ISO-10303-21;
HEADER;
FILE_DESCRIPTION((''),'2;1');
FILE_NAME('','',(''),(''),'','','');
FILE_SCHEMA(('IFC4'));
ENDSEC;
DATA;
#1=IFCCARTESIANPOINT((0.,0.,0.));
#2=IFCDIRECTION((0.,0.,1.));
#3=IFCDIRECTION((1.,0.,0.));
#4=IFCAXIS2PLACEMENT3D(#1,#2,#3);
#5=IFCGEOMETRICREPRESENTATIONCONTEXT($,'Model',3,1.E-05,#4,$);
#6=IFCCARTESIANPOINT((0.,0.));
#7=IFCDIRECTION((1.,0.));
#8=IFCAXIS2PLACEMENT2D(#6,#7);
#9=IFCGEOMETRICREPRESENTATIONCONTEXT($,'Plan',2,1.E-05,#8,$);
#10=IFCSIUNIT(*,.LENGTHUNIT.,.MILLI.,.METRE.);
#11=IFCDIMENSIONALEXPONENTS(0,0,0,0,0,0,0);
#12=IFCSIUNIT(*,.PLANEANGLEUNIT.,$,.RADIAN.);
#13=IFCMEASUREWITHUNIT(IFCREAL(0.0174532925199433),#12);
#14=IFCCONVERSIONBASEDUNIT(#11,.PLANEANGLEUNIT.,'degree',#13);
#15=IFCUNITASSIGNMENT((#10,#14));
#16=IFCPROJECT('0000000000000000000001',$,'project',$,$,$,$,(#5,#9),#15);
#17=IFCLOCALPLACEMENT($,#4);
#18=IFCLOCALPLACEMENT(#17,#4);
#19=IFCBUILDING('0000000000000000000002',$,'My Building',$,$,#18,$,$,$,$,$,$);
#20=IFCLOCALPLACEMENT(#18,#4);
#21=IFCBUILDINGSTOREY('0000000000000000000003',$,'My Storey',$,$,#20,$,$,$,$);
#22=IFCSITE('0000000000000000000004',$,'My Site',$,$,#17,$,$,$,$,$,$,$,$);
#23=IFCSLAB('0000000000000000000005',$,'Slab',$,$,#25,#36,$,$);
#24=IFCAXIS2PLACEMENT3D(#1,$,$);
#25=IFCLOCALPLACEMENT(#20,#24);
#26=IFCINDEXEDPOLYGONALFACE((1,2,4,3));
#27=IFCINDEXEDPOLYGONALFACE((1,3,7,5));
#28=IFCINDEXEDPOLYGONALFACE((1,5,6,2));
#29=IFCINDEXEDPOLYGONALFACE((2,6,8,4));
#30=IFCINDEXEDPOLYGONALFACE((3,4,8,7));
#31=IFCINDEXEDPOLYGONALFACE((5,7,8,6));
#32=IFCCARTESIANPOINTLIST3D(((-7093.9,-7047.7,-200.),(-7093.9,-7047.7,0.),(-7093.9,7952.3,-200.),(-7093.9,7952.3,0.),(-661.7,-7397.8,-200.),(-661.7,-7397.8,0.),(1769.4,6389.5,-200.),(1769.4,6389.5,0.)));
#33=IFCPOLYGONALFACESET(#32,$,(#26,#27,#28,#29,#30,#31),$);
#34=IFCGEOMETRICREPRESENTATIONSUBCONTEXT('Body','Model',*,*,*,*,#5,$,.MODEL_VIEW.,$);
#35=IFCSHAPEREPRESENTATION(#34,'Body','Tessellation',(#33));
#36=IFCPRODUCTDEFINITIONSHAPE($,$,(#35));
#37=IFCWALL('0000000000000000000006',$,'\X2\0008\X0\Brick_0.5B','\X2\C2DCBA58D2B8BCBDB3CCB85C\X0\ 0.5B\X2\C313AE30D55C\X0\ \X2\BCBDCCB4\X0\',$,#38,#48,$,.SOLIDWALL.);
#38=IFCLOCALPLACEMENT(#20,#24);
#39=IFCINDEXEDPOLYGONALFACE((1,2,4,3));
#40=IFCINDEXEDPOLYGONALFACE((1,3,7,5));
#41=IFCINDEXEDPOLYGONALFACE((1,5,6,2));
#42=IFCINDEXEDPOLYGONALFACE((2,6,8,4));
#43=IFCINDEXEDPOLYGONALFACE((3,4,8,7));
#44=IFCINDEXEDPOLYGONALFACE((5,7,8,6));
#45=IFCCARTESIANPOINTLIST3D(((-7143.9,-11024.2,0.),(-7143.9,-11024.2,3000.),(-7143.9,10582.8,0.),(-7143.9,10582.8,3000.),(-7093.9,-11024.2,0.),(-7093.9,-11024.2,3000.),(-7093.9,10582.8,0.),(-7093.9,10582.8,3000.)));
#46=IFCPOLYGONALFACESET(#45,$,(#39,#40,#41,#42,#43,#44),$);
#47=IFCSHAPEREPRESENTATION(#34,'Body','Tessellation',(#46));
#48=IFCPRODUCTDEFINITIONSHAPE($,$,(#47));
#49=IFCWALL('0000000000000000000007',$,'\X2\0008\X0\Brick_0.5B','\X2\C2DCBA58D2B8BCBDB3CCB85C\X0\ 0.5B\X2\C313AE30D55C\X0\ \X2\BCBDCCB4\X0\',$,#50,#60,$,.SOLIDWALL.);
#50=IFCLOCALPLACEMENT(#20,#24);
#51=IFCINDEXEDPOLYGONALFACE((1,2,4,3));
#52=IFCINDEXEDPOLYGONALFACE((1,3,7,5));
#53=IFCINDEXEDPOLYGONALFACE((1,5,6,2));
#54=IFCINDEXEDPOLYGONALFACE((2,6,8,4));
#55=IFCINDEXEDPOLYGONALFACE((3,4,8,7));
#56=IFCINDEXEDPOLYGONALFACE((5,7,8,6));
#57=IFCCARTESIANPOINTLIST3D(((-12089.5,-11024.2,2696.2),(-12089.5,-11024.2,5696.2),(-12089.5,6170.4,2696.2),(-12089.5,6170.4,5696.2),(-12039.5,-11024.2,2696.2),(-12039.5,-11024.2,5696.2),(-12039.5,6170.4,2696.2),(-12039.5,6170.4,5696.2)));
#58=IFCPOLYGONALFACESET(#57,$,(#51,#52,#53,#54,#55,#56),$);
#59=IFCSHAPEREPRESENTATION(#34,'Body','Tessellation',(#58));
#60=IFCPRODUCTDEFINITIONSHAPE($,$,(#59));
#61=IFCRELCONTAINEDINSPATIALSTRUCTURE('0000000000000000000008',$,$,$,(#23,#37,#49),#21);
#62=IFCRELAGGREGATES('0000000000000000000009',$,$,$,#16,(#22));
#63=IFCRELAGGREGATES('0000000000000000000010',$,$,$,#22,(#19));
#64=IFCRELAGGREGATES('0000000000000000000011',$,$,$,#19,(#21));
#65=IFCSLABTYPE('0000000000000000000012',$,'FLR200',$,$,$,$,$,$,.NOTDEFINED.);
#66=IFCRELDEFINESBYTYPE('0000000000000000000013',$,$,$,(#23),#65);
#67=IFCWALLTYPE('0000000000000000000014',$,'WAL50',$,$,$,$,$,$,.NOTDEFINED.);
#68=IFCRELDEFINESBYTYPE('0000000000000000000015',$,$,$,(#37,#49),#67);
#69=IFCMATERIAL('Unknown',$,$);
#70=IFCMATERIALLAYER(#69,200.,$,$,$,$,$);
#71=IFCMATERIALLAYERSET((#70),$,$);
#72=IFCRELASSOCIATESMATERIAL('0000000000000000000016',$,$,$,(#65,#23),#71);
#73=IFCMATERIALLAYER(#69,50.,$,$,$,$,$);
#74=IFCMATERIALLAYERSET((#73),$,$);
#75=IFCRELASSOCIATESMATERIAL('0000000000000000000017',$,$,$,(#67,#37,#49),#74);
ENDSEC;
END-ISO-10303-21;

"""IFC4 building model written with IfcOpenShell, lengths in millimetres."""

from ifc_helpers import new_model, entity, si_unit, converted_unit, frame, origin_with_axes, origin_2d_with_axis, place, context, subcontext, project, spatial, line, indexed_curve, outline, extrude, material, layer, layer_set, layer_usage, type_object, element, save


model = new_model("IFC4")

# Units and contexts
model_context = context("Model", 3, precision=1e-05, world=origin_with_axes())
plan_context = context("Plan", 2, precision=1e-05, world=origin_2d_with_axis())
body_context = subcontext(model_context, "Body", "Model", "MODEL_VIEW")
ifc_project = project(units=[si_unit("LENGTHUNIT", "METRE", prefix="MILLI"), converted_unit("PLANEANGLEUNIT", "degree", entity("IfcReal", 0.0174532925199433), si_unit("PLANEANGLEUNIT", "RADIAN"), dimensions=[0, 0, 0, 0, 0, 0, 0])], contexts=[model_context, plan_context])

# Site, building, storey
site_placement = place(None, origin_with_axes())
site = spatial("IfcSite", under=ifc_project, at=site_placement, Name="My Site")
building_placement = place(site_placement, origin_with_axes())
building = spatial("IfcBuilding", under=site, at=building_placement, Name="My Building")
storey_placement = place(building_placement, origin_with_axes())
storey = spatial("IfcBuildingStorey", under=building, at=storey_placement, Name="My Storey")

# Slab
ifc_material = material(Name="Unknown")
ifc_layer_1 = layer(ifc_material, 200.0)
ifc_layer_set_1 = layer_set([ifc_layer_1])
ifc_layer_usage_1 = layer_usage(ifc_layer_set_1, "AXIS3", "POSITIVE", -200.0)
slab_type = type_object("IfcSlabType", Name="FLR200", PredefinedType="NOTDEFINED", material=ifc_layer_set_1)
slab_placement = place(storey_placement, frame((-7093.9, -7047.7, 0.0), z_axis=(0.0, 0.0, 1.0), x_axis=(1.0, 0.0, 0.0)))
element("IfcSlab", 1, at=slab_placement, inside=storey, type_object=slab_type, material=ifc_layer_usage_1, Name="Slab", context=body_context, shape_type="SweptSolid", body=[
    extrude(outline(indexed_curve([(0.0, 0.0), (0.0, 15000.0), (8863.3, 13437.2), (6432.2, -350.1), (0.0, 0.0)])), frame((0.0, 0.0, -200.0), z_axis=(0.0, 0.0, 1.0), x_axis=(1.0, 0.0, 0.0)), (0.0, 0.0, 1.0), 200.0),
])

# Walls
ifc_layer_2 = layer(ifc_material, 50.0)
ifc_layer_set_2 = layer_set([ifc_layer_2])
ifc_layer_usage_2 = layer_usage(ifc_layer_set_2, "AXIS2", "POSITIVE", 0.0)
wall_type = type_object("IfcWallType", Name="WAL50", PredefinedType="NOTDEFINED", material=ifc_layer_set_2)
wall_1_placement = place(storey_placement, frame((-7093.9, -11024.2, 0.0), z_axis=(0.0, 0.0, 1.0), x_axis=(0.0, 1.0, 0.0)))
element("IfcWall", 2, at=wall_1_placement, inside=storey, type_object=wall_type, material=ifc_layer_usage_2, Name="\bBrick_0.5B", Description="시멘트벽돌로 0.5B쌓기한 벽체", PredefinedType="SOLIDWALL", context=body_context, shape_type="SweptSolid", body=[
    extrude(outline(indexed_curve([(0.0, 0.0), (0.0, 50.0), (21607.0, 50.0), (21607.0, 0.0)], segments=[line(1, 2, 3, 4, 1)])), origin_with_axes(), (0.0, 0.0, 1.0), 3000.0),
])
ifc_layer_usage_3 = layer_usage(ifc_layer_set_2, "AXIS2", "POSITIVE", 0.0)
wall_2_placement = place(storey_placement, frame((-12039.5, -11024.2, 2696.2), z_axis=(0.0, 0.0, 1.0), x_axis=(0.0, 1.0, 0.0)))
element("IfcWall", 3, at=wall_2_placement, inside=storey, type_object=wall_type, material=ifc_layer_usage_3, Name="\bBrick_0.5B", Description="시멘트벽돌로 0.5B쌓기한 벽체", PredefinedType="SOLIDWALL", context=body_context, shape_type="SweptSolid", body=[
    extrude(outline(indexed_curve([(0.0, 0.0), (0.0, 50.0), (17194.6, 50.0), (17194.6, 0.0)], segments=[line(1, 2, 3, 4, 1)])), origin_with_axes(), (0.0, 0.0, 1.0), 3000.0),
])

save(model, "model.ifc")
